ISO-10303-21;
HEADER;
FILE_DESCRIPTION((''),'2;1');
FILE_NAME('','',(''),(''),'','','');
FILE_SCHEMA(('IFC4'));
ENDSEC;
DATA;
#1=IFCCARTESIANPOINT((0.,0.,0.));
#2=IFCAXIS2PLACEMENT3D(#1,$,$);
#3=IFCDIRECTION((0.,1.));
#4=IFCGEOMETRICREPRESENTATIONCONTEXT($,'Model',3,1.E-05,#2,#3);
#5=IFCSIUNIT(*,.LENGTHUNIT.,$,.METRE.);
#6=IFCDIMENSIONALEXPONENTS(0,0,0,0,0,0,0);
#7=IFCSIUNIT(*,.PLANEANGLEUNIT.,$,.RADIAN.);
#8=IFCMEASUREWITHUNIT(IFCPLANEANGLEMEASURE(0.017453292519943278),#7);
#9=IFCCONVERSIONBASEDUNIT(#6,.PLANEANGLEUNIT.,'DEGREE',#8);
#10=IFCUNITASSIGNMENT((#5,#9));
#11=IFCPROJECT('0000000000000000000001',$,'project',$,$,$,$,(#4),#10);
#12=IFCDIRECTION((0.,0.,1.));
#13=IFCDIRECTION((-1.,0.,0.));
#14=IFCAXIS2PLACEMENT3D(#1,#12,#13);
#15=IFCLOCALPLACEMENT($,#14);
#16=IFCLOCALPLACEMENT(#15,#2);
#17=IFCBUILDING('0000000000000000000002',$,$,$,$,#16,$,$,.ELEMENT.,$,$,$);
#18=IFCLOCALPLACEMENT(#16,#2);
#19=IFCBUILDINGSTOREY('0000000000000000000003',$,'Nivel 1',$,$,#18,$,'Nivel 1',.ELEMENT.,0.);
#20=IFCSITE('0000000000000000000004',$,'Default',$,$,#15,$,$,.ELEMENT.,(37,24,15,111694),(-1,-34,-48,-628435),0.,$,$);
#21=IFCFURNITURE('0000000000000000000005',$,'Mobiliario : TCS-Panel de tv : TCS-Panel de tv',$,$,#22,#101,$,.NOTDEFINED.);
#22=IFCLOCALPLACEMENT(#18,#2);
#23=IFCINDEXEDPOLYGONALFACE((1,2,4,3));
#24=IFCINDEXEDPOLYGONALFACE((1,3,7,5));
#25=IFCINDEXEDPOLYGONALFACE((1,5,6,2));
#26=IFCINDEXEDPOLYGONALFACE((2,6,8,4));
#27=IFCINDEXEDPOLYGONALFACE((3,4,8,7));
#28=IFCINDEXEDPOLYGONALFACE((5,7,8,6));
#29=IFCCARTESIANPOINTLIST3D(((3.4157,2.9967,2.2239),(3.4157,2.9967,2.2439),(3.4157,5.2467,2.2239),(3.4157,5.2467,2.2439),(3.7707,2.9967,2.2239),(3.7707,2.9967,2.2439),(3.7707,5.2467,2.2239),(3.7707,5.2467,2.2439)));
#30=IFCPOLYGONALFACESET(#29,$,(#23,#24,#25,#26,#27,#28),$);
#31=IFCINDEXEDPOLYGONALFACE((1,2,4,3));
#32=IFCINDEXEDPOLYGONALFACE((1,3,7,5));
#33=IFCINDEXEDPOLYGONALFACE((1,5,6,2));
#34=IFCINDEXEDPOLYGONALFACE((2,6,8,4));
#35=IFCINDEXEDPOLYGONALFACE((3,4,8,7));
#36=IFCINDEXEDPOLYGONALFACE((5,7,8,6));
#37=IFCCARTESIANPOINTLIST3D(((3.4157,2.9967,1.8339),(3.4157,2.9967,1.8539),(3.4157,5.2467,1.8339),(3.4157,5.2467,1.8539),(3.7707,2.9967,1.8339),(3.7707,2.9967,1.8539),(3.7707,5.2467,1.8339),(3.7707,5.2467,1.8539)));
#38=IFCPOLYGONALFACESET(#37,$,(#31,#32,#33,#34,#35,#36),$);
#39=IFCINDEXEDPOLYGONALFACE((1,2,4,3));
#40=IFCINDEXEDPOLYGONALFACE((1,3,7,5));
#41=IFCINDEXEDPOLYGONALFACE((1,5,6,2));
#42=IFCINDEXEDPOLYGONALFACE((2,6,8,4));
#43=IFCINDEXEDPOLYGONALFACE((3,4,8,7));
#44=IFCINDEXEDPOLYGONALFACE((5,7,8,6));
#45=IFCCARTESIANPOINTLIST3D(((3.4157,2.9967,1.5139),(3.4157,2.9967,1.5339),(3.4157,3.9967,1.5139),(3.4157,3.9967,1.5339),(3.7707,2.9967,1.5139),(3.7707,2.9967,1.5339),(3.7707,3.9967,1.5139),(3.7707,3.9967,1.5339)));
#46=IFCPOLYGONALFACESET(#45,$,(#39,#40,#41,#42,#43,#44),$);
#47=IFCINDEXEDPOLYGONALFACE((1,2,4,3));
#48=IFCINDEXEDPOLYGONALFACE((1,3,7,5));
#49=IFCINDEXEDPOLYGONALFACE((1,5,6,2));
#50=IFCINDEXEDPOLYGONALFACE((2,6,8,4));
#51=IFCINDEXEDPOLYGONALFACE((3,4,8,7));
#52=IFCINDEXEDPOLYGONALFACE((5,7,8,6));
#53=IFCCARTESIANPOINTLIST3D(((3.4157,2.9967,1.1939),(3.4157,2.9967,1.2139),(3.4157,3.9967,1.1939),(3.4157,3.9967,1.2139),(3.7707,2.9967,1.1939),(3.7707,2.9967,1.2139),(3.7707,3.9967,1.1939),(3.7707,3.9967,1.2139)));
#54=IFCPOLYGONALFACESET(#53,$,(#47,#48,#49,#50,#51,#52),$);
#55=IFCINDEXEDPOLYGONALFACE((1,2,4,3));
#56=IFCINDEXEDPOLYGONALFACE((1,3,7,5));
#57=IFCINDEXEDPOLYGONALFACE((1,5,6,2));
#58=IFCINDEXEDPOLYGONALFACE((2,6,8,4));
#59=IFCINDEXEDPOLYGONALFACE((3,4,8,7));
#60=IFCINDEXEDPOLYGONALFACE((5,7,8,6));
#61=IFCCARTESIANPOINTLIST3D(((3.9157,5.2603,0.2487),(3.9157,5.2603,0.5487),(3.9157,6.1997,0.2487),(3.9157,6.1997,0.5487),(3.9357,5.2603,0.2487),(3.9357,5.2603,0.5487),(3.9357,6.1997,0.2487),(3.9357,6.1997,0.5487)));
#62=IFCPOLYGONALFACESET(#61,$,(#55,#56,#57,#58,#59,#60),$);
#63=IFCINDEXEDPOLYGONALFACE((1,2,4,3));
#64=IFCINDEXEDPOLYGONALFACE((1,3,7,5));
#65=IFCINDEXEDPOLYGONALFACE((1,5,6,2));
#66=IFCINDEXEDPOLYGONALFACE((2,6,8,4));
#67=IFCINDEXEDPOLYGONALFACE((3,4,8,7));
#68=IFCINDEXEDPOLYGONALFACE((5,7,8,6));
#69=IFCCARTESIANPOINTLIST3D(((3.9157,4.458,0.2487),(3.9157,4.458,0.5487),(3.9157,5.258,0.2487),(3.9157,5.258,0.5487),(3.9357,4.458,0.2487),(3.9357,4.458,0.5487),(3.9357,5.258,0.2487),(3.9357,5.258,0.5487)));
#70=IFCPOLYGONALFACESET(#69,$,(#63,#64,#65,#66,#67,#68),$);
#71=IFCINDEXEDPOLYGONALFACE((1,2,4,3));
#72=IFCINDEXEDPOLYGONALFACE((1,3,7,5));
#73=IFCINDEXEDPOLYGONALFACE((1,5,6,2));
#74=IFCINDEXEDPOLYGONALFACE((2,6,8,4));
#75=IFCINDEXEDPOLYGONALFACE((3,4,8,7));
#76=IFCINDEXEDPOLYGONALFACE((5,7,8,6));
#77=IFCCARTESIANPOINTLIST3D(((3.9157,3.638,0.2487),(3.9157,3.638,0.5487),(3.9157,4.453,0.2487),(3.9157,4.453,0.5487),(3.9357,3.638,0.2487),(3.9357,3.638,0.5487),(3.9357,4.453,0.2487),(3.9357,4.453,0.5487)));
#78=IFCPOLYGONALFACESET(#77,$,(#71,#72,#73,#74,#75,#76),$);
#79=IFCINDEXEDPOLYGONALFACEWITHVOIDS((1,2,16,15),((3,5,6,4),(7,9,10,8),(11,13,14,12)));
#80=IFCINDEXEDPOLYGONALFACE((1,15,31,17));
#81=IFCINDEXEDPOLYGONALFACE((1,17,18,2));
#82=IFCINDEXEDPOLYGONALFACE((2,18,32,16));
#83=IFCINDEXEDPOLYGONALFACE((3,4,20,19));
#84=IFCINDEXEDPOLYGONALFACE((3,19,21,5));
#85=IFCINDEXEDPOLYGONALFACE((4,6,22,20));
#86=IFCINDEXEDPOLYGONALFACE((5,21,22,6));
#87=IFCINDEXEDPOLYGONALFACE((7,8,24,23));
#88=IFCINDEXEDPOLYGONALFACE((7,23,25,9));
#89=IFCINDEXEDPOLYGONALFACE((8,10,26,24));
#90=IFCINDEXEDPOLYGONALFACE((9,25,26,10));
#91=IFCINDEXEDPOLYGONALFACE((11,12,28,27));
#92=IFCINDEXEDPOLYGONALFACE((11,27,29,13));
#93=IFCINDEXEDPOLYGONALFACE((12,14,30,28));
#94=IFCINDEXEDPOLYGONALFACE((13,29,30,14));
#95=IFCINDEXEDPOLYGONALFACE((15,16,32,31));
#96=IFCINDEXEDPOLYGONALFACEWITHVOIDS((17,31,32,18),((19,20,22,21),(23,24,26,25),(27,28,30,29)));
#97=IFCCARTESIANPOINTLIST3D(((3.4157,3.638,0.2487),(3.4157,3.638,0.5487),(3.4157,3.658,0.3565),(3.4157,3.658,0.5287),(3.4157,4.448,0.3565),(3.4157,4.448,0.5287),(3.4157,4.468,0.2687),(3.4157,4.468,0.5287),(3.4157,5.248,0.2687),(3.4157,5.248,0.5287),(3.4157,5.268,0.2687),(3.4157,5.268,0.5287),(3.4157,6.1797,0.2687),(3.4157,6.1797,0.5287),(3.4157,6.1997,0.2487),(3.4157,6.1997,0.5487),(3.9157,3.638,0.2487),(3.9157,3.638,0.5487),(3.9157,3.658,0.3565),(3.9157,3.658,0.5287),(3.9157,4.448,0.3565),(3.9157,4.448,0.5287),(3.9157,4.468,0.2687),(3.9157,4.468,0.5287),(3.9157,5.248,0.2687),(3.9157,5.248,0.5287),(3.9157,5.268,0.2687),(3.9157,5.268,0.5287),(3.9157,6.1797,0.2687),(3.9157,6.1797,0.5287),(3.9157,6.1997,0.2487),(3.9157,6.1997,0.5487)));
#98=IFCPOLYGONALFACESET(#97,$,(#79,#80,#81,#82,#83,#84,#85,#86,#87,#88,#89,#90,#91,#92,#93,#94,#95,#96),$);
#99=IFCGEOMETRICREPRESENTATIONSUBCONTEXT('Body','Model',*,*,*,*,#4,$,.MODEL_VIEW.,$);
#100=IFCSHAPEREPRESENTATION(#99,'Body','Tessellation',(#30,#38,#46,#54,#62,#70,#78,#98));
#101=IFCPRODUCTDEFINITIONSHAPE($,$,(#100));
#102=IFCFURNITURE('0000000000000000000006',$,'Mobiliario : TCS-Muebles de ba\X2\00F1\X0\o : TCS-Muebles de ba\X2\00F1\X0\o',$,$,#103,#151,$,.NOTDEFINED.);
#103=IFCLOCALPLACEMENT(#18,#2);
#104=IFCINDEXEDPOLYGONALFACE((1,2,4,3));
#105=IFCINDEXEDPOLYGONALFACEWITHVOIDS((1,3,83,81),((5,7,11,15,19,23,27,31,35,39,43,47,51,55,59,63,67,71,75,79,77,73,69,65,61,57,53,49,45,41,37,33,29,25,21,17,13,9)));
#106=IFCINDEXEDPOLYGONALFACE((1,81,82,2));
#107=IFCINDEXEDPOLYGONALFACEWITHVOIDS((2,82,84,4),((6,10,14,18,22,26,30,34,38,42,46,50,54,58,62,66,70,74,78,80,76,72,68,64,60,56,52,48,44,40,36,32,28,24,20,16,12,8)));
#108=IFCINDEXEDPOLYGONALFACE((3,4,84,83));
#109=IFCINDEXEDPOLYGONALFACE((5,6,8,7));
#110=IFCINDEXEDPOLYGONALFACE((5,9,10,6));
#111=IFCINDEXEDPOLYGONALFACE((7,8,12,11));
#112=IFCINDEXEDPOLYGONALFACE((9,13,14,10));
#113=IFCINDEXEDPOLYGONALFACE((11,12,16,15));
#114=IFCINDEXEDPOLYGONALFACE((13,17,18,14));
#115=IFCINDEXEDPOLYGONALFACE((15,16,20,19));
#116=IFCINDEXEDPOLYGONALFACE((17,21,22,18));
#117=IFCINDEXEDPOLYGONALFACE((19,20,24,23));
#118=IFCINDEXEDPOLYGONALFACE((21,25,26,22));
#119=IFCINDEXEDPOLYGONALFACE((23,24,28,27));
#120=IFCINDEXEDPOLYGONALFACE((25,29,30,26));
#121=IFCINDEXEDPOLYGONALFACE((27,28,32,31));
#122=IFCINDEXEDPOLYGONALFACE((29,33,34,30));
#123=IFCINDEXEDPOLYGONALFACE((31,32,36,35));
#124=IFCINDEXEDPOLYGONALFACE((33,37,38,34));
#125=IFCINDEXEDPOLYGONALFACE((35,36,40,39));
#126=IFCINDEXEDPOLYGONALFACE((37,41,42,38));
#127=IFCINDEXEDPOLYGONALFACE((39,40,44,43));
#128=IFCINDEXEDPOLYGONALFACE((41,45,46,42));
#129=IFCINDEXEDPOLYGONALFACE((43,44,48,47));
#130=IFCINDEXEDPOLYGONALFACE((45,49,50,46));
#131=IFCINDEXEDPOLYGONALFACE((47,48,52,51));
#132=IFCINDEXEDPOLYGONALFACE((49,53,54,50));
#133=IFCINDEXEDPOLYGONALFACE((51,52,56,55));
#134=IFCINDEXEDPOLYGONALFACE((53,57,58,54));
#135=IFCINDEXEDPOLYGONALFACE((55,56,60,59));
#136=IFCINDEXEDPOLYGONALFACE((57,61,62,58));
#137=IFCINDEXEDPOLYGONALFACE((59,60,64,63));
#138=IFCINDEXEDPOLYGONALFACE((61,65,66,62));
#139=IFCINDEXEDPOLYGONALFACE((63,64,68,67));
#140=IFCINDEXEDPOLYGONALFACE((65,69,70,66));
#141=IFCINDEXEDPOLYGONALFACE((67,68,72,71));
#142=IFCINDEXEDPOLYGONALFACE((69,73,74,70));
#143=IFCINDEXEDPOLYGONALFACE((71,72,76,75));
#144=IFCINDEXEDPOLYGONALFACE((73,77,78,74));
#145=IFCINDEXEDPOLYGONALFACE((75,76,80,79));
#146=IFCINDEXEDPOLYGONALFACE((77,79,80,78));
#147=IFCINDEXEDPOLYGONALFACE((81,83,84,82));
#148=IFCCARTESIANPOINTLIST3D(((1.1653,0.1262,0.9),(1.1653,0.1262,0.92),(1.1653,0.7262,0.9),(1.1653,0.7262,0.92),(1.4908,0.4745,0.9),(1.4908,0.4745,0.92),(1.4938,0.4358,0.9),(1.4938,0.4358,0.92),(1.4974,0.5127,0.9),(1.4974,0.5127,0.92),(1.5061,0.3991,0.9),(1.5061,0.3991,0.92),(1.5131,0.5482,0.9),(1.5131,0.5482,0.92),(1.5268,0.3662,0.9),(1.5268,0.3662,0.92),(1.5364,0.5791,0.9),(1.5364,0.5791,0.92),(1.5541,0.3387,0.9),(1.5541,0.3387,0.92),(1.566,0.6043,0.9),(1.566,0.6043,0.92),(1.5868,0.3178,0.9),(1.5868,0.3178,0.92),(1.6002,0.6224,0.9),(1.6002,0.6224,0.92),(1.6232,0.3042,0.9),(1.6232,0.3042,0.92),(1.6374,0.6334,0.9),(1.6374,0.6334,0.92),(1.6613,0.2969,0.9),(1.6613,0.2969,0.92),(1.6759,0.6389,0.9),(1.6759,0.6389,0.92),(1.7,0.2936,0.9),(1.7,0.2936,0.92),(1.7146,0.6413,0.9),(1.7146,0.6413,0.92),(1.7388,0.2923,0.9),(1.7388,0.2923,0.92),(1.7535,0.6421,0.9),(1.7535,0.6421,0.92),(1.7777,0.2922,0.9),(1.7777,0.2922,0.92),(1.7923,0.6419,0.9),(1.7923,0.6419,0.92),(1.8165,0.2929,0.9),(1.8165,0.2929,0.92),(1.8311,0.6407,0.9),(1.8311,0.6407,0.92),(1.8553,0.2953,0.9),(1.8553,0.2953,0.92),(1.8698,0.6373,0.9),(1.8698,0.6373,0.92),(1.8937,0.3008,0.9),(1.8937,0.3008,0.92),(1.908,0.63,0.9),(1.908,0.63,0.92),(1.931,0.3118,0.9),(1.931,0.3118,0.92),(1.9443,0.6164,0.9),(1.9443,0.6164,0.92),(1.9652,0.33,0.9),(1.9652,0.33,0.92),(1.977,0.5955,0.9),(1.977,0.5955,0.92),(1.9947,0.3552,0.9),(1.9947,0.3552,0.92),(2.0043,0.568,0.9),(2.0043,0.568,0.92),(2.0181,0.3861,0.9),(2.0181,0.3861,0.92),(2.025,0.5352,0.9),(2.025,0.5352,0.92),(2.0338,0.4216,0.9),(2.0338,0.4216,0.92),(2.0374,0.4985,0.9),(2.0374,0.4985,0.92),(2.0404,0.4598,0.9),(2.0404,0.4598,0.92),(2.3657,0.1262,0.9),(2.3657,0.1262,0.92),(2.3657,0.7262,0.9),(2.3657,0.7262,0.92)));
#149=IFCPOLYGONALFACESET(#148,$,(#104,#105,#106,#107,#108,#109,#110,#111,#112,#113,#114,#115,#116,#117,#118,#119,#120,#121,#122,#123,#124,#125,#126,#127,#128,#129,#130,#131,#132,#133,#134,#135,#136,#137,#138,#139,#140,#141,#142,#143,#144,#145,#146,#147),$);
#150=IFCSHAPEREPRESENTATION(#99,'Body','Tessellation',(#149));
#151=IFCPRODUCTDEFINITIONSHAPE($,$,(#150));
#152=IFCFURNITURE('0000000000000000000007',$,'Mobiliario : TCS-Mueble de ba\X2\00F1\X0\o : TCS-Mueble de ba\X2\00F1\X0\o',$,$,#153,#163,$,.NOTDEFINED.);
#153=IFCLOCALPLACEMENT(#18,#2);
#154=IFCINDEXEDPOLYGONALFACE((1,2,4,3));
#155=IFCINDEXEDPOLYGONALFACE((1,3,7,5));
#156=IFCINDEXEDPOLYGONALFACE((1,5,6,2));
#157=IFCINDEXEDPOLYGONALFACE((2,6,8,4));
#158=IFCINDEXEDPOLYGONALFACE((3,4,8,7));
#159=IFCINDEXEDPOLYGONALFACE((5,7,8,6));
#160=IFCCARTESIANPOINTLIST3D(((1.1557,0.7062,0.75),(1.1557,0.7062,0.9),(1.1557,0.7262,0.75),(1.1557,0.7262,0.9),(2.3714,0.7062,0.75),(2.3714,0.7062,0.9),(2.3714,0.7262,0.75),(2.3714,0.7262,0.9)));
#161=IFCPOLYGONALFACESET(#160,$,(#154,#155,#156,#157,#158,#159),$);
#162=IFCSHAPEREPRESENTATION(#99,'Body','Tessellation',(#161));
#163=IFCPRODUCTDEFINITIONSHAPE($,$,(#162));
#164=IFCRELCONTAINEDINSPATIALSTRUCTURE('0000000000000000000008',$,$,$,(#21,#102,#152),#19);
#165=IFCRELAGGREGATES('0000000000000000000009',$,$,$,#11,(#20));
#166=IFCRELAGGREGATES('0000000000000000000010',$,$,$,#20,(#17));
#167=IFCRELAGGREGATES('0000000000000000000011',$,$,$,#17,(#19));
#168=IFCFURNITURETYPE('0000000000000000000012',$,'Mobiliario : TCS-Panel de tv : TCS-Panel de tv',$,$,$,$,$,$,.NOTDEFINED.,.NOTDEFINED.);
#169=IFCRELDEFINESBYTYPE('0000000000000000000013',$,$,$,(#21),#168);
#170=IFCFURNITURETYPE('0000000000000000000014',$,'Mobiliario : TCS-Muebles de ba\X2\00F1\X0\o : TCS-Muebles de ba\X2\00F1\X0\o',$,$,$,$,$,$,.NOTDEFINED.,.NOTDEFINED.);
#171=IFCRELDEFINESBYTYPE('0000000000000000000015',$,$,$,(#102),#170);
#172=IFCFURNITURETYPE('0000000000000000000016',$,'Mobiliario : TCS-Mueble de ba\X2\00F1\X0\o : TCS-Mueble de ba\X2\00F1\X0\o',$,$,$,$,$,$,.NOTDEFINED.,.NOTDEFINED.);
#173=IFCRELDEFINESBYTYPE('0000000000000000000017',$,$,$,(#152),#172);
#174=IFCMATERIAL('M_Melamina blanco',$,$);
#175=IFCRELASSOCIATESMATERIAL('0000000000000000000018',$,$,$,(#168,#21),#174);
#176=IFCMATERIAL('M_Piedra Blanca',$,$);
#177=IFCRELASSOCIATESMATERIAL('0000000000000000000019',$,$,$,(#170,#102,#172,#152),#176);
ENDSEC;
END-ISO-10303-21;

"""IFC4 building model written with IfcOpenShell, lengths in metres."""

from ifc_helpers import new_model, entity, si_unit, converted_unit, direction, frame, origin, place, context, subcontext, project, spatial, indexed_curve, outline, extrude, source, transform, mapped, material, type_object, type_shapes, element, save


model = new_model("IFC4")

# Units and contexts
model_context = context("Model", 3, precision=1e-05, world=origin(), true_north=direction((0.0, 1.0)))
body_context = subcontext(model_context, "Body", "Model", "MODEL_VIEW")
ifc_project = project(units=[si_unit("LENGTHUNIT", "METRE"), converted_unit("PLANEANGLEUNIT", "DEGREE", entity("IfcPlaneAngleMeasure", 0.017453292519943278), si_unit("PLANEANGLEUNIT", "RADIAN"), dimensions=[0, 0, 0, 0, 0, 0, 0])], contexts=[model_context])

# Site, building, storey
site_placement = place(None, frame((0.0, 0.0, 0.0), z_axis=(0.0, 0.0, 1.0), x_axis=(-1.0, 0.0, 0.0)))
site = spatial("IfcSite", under=ifc_project, at=site_placement, Name="Default", CompositionType="ELEMENT", RefLatitude=(37, 24, 15, 111694), RefLongitude=(-1, -34, -48, -628435), RefElevation=0.0)
building_placement = place(site_placement, origin())
building = spatial("IfcBuilding", under=site, at=building_placement, CompositionType="ELEMENT")
storey_placement = place(building_placement, origin())
storey = spatial("IfcBuildingStorey", under=building, at=storey_placement, Name="Nivel 1", LongName="Nivel 1", CompositionType="ELEMENT", Elevation=0.0)

# Furniture
ifc_material_1 = material(Name="M_Piedra Blanca")
ifc_material_2 = material(Name="M_Melamina blanco")
furniture_type_1 = type_object("IfcFurnitureType", Name="Mobiliario : TCS-Panel de tv : TCS-Panel de tv", AssemblyPlace="NOTDEFINED", PredefinedType="NOTDEFINED", material=ifc_material_2)
shared_shape_1 = source(origin(), body_context, "Body", "SweptSolid", [
    extrude(outline(indexed_curve([(-0.1775, -1.125), (0.1775, -1.125), (0.1775, 1.125), (-0.1775, 1.125), (-0.1775, -1.125)], self_intersect=False)), frame((3.5932, 4.1217, 2.2239), z_axis=(0.0, 0.0, 1.0), x_axis=(-1.0, 0.0, 0.0)), (0.0, 0.0, 1.0), 0.02),
    extrude(outline(indexed_curve([(-0.1775, -1.125), (0.1775, -1.125), (0.1775, 1.125), (-0.1775, 1.125), (-0.1775, -1.125)], self_intersect=False)), frame((3.5932, 4.1217, 1.8339), z_axis=(0.0, 0.0, 1.0), x_axis=(-1.0, 0.0, 0.0)), (0.0, 0.0, 1.0), 0.02),
    extrude(outline(indexed_curve([(-0.1775, -0.5), (0.1775, -0.5), (0.1775, 0.5), (-0.1775, 0.5), (-0.1775, -0.5)], self_intersect=False)), frame((3.5932, 3.4967, 1.5139), z_axis=(0.0, 0.0, 1.0), x_axis=(-1.0, 0.0, 0.0)), (0.0, 0.0, 1.0), 0.02),
    extrude(outline(indexed_curve([(-0.1775, -0.5), (0.1775, -0.5), (0.1775, 0.5), (-0.1775, 0.5), (-0.1775, -0.5)], self_intersect=False)), frame((3.5932, 3.4967, 1.1939), z_axis=(0.0, 0.0, 1.0), x_axis=(-1.0, 0.0, 0.0)), (0.0, 0.0, 1.0), 0.02),
    extrude(outline(indexed_curve([(-0.01, -0.4697), (0.01, -0.4697), (0.01, 0.4697), (-0.01, 0.4697), (-0.01, -0.4697)], self_intersect=False)), frame((3.9257, 5.73, 0.2487), z_axis=(0.0, 0.0, 1.0), x_axis=(-1.0, 0.0, 0.0)), (0.0, 0.0, 1.0), 0.3),
    extrude(outline(indexed_curve([(-0.01, -0.4), (0.01, -0.4), (0.01, 0.4), (-0.01, 0.4), (-0.01, -0.4)], self_intersect=False)), frame((3.9257, 4.858, 0.2487), z_axis=(0.0, 0.0, 1.0), x_axis=(-1.0, 0.0, 0.0)), (0.0, 0.0, 1.0), 0.3),
    extrude(outline(indexed_curve([(-0.01, -0.4075), (0.01, -0.4075), (0.01, 0.4075), (-0.01, 0.4075), (-0.01, -0.4075)], self_intersect=False)), frame((3.9257, 4.0455, 0.2487), z_axis=(0.0, 0.0, 1.0), x_axis=(-1.0, 0.0, 0.0)), (0.0, 0.0, 1.0), 0.3),
    extrude(outline(indexed_curve([(-0.15, -1.2809), (0.15, -1.2809), (0.15, 1.2809), (-0.15, 1.2809), (-0.15, -1.2809)], self_intersect=False), holes=[indexed_curve([(0.0421, -1.2609), (-0.13, -1.2609), (-0.13, -0.4709), (0.0421, -0.4709), (0.0421, -1.2609)], self_intersect=False), indexed_curve([(0.13, 1.2609), (0.13, 0.3491), (-0.13, 0.3491), (-0.13, 1.2609), (0.13, 1.2609)], self_intersect=False), indexed_curve([(-0.13, -0.4509), (-0.13, 0.3291), (0.13, 0.3291), (0.13, -0.4509), (-0.13, -0.4509)], self_intersect=False)]), frame((3.4157, 4.9188, 0.3987), z_axis=(1.0, 0.0, 0.0), x_axis=(0.0, 0.0, -1.0)), (0.0, 0.0, 1.0), 0.5),
])
type_shapes(furniture_type_1, [shared_shape_1])
furniture_1_placement = place(storey_placement, origin())
element("IfcFurniture", 1, at=furniture_1_placement, inside=storey, type_object=furniture_type_1, material=ifc_material_2, Name="Mobiliario : TCS-Panel de tv : TCS-Panel de tv", PredefinedType="NOTDEFINED", context=body_context, shape_type="MappedRepresentation", body=[
    mapped(shared_shape_1, transform((0.0, 0.0, 0.0), scale=1.0)),
])
furniture_type_2 = type_object("IfcFurnitureType", Name="Mobiliario : TCS-Muebles de baño : TCS-Muebles de baño", AssemblyPlace="NOTDEFINED", PredefinedType="NOTDEFINED", material=ifc_material_1)
shared_shape_2 = source(origin(), body_context, "Body", "SweptSolid", [
    extrude(outline(indexed_curve([(-0.6002, -0.3), (0.6002, -0.3), (0.6002, 0.3), (-0.6002, 0.3), (-0.6002, -0.3)], self_intersect=False), holes=[indexed_curve([(0.2524, -0.1219), (0.2291, -0.1529), (0.1995, -0.178), (0.1653, -0.1962), (0.1281, -0.2072), (0.0896, -0.2127), (0.0509, -0.2151), (0.012, -0.2158), (-0.0268, -0.2157), (-0.0656, -0.2144), (-0.1043, -0.2111), (-0.1425, -0.2038), (-0.1788, -0.1902), (-0.2115, -0.1693), (-0.2388, -0.1418), (-0.2595, -0.109), (-0.2719, -0.0722), (-0.2749, -0.0336), (-0.2683, 0.0046), (-0.2526, 0.0401), (-0.2292, 0.071), (-0.1997, 0.0962), (-0.1655, 0.1144), (-0.1282, 0.1254), (-0.0898, 0.1309), (-0.051, 0.1333), (-0.0122, 0.1341), (0.0267, 0.1339), (0.0655, 0.1327), (0.1042, 0.1293), (0.1423, 0.122), (0.1787, 0.1084), (0.2114, 0.0875), (0.2387, 0.06), (0.2594, 0.0272), (0.2717, -0.0096), (0.2748, -0.0483), (0.2681, -0.0865), (0.2524, -0.1219)], self_intersect=False)]), frame((1.7655, 0.4262, 0.9), z_axis=(0.0, 0.0, 1.0), x_axis=(-1.0, 0.0, 0.0)), (0.0, 0.0, 1.0), 0.02),
])
type_shapes(furniture_type_2, [shared_shape_2])
furniture_2_placement = place(storey_placement, origin())
element("IfcFurniture", 2, at=furniture_2_placement, inside=storey, type_object=furniture_type_2, material=ifc_material_1, Name="Mobiliario : TCS-Muebles de baño : TCS-Muebles de baño", PredefinedType="NOTDEFINED", context=body_context, shape_type="MappedRepresentation", body=[
    mapped(shared_shape_2, transform((0.0, 0.0, 0.0), scale=1.0)),
])
furniture_type_3 = type_object("IfcFurnitureType", Name="Mobiliario : TCS-Mueble de baño : TCS-Mueble de baño", AssemblyPlace="NOTDEFINED", PredefinedType="NOTDEFINED", material=ifc_material_1)
shared_shape_3 = source(origin(), body_context, "Body", "SweptSolid", [
    extrude(outline(indexed_curve([(-0.01, -0.6078), (0.01, -0.6078), (0.01, 0.6078), (-0.01, 0.6078), (-0.01, -0.6078)], self_intersect=False)), frame((1.7635, 0.7162, 0.75), z_axis=(0.0, 0.0, 1.0), x_axis=(0.0, -1.0, 0.0)), (0.0, 0.0, 1.0), 0.15),
])
type_shapes(furniture_type_3, [shared_shape_3])
furniture_3_placement = place(storey_placement, origin())
element("IfcFurniture", 3, at=furniture_3_placement, inside=storey, type_object=furniture_type_3, material=ifc_material_1, Name="Mobiliario : TCS-Mueble de baño : TCS-Mueble de baño", PredefinedType="NOTDEFINED", context=body_context, shape_type="MappedRepresentation", body=[
    mapped(shared_shape_3, transform((0.0, 0.0, 0.0), scale=1.0)),
])

save(model, "model.ifc")
